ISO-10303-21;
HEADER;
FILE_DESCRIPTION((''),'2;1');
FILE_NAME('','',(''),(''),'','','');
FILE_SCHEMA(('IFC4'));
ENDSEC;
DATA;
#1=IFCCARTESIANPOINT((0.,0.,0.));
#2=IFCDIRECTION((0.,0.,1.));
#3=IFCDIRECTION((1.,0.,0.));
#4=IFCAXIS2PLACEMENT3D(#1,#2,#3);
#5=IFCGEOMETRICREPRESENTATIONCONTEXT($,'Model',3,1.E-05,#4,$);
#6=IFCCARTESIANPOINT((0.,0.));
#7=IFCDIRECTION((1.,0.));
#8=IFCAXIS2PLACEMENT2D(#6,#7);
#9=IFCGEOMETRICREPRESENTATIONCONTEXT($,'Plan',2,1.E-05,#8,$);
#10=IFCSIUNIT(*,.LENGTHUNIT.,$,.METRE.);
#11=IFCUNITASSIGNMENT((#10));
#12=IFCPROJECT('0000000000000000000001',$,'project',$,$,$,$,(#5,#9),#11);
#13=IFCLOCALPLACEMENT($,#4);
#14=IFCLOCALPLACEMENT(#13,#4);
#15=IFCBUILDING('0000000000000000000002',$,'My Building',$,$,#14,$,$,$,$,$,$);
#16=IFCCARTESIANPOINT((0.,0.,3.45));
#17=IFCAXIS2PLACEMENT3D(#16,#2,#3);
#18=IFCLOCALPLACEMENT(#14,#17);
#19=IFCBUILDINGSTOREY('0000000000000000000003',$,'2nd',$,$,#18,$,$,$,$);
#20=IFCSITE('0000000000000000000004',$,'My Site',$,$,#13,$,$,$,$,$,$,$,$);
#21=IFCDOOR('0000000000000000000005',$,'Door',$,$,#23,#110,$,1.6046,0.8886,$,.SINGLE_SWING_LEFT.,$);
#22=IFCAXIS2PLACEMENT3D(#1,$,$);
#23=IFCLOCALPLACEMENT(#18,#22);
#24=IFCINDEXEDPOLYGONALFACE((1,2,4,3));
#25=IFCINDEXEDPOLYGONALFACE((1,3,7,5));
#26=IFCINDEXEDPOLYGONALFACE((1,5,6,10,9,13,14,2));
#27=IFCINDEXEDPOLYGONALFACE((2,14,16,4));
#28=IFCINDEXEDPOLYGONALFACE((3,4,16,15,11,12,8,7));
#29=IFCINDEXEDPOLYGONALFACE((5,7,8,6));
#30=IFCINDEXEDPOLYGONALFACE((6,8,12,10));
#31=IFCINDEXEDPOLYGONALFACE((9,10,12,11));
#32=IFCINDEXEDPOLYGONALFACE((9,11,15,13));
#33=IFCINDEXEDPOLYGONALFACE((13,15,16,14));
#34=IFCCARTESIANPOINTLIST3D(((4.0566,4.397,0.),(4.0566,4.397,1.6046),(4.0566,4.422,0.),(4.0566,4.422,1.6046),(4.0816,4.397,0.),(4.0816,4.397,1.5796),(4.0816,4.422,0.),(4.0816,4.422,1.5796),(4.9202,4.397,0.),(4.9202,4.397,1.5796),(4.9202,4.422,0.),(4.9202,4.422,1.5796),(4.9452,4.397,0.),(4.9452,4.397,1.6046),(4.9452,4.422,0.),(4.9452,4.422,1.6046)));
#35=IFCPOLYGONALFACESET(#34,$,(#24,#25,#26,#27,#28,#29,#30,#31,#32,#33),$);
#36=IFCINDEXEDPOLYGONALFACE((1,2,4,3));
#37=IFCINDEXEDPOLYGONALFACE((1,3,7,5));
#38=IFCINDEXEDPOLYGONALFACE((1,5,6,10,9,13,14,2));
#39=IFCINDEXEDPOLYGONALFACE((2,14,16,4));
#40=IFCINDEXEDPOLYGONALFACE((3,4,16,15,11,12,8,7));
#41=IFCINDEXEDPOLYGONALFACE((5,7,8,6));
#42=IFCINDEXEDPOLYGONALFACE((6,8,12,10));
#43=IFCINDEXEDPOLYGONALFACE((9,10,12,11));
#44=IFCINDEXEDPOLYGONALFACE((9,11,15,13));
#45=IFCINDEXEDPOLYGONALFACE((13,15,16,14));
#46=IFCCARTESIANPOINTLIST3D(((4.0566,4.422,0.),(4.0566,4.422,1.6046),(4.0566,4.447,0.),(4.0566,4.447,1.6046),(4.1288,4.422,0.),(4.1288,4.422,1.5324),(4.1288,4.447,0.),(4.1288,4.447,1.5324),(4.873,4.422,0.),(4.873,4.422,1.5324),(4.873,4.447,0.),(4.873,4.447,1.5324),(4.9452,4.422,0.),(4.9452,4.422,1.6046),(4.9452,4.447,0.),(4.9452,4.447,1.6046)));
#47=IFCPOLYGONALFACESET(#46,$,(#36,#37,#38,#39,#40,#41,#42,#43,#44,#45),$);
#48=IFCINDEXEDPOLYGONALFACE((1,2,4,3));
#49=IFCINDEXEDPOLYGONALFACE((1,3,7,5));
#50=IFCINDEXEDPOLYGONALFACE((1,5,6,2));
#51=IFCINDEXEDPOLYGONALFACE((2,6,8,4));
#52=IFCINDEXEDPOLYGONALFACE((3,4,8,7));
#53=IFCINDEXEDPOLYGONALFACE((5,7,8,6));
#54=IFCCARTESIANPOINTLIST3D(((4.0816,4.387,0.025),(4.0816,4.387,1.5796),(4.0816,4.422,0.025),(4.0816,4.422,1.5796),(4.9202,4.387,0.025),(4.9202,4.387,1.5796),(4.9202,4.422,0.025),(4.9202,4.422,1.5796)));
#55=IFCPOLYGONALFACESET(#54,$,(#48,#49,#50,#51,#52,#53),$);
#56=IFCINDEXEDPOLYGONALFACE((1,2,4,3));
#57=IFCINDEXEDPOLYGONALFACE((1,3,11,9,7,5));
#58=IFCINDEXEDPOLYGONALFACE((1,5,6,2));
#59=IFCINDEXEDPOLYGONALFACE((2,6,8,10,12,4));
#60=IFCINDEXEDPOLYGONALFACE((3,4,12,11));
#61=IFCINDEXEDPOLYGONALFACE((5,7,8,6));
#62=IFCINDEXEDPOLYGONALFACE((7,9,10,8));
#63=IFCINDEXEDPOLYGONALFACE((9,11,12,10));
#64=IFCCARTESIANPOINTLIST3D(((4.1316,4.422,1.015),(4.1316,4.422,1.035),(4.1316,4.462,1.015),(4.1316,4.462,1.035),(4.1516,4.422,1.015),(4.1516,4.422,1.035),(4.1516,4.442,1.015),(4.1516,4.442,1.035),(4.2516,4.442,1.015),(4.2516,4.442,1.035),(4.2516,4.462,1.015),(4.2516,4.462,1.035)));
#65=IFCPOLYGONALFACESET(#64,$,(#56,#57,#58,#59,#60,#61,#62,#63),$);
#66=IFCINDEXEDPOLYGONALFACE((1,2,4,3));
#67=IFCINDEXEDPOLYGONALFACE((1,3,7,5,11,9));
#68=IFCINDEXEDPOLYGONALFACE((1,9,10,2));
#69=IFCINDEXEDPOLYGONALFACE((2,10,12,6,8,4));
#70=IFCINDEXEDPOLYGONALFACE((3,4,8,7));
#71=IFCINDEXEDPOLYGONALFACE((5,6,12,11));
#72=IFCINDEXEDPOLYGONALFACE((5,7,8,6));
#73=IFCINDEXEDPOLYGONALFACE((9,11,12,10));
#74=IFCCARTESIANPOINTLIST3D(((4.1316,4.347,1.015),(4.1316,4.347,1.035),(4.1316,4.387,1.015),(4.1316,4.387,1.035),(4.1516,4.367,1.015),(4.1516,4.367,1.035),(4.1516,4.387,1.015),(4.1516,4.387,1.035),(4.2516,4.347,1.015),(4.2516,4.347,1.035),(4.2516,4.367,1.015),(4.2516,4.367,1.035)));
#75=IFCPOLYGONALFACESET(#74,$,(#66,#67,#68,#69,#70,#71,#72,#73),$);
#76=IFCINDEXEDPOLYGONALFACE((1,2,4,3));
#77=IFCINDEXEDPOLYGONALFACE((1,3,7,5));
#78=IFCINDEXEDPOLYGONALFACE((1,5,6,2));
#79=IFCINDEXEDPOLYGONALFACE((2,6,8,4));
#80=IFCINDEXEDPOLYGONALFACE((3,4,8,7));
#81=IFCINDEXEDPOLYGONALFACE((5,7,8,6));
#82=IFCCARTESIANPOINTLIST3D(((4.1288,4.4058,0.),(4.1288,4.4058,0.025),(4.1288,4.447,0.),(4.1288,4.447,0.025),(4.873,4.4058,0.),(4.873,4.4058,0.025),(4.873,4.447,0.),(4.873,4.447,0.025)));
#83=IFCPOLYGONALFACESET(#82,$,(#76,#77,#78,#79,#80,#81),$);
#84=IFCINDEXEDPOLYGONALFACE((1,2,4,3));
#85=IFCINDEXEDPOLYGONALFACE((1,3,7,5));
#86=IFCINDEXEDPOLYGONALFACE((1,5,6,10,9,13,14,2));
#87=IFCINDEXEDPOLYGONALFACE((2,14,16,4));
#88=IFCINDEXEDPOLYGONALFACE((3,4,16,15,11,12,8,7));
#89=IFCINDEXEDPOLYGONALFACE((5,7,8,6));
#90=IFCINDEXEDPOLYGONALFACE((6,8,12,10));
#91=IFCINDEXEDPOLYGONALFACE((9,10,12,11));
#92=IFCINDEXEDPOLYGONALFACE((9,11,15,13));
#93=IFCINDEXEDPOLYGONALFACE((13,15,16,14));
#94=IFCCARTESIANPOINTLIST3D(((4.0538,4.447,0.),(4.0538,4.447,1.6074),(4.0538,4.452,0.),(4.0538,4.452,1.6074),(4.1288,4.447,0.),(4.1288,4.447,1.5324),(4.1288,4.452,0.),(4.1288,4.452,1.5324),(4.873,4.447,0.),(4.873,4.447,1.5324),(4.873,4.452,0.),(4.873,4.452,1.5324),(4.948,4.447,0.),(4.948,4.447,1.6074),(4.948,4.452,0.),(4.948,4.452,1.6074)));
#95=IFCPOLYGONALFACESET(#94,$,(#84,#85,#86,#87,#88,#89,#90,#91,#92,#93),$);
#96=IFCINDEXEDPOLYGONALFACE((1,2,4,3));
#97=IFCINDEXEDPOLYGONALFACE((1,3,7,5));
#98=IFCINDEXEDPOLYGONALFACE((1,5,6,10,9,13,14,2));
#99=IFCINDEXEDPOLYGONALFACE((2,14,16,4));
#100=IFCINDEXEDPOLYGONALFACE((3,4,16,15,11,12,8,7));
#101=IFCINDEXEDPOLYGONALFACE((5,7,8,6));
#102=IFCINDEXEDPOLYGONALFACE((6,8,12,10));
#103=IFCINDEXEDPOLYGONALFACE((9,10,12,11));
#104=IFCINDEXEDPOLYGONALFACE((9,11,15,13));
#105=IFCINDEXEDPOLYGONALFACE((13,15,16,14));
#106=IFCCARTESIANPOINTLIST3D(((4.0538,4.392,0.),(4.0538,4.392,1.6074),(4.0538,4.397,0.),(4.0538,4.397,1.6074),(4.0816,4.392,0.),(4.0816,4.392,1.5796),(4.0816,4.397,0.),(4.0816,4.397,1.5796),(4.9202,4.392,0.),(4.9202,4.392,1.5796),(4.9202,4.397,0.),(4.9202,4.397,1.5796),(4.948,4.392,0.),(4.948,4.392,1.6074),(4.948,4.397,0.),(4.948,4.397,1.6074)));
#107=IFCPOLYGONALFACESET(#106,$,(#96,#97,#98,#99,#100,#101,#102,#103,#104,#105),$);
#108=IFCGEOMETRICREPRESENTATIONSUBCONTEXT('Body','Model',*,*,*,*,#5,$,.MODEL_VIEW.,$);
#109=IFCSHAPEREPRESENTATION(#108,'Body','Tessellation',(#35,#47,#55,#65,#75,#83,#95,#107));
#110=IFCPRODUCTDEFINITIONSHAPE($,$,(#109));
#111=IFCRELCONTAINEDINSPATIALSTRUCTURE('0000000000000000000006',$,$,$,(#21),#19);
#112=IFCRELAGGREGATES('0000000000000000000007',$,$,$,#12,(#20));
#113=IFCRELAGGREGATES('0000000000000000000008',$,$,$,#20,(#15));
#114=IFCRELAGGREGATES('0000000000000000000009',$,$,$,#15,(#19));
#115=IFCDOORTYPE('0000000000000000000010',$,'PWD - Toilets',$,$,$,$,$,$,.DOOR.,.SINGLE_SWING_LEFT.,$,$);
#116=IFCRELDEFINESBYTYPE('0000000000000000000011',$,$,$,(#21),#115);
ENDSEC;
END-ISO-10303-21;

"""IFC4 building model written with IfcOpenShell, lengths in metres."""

from ifc_helpers import new_model, entity, si_unit, frame, origin_with_axes, origin_2d_with_axis, place, context, subcontext, project, spatial, line, indexed_curve, outline, extrude, shape, source, transform, mapped, type_object, type_shapes, element, save


model = new_model("IFC4")

# Units and contexts
model_context = context("Model", 3, precision=1e-05, world=origin_with_axes())
plan_context = context("Plan", 2, precision=1e-05, world=origin_2d_with_axis())
body_context_1 = subcontext(model_context, "Body", "Model", "MODEL_VIEW")
body_context_2 = subcontext(plan_context, "Body", "Plan", "PLAN_VIEW")
ifc_project = project(units=[si_unit("LENGTHUNIT", "METRE")], contexts=[model_context, plan_context])

# Site, building, storey
site_placement = place(None, origin_with_axes())
site = spatial("IfcSite", under=ifc_project, at=site_placement, Name="My Site")
building_placement = place(site_placement, origin_with_axes())
building = spatial("IfcBuilding", under=site, at=building_placement, Name="My Building")
storey_placement = place(building_placement, frame((0.0, 0.0, 3.45), z_axis=(0.0, 0.0, 1.0), x_axis=(1.0, 0.0, 0.0)))
storey = spatial("IfcBuildingStorey", under=building, at=storey_placement, Name="2nd")

# Door
door_type_1 = type_object("IfcDoorType", Name="PWD - Toilets", OperationType="SINGLE_SWING_LEFT", PredefinedType="DOOR")
shared_shape_1 = source(origin_with_axes(), body_context_1, "Body", "SweptSolid", [
    extrude(outline(indexed_curve([(0.0, 0.0), (0.0, 1.6046), (0.8886, 1.6046), (0.8886, 0.0), (0.8636, 0.0), (0.8636, 1.5796), (0.025, 1.5796), (0.025, 0.0)], segments=[line(1, 2, 3, 4, 5, 6, 7, 8, 1)])), frame((0.0, 0.025, 0.0), z_axis=(0.0, -1.0, 0.0), x_axis=(1.0, 0.0, 0.0)), (0.0, 0.0, -1.0), 0.025),
    extrude(outline(indexed_curve([(0.0, 0.0), (0.0, 1.6046), (0.8886, 1.6046), (0.8886, 0.0), (0.8164, 0.0), (0.8164, 1.5324), (0.0722, 1.5324), (0.0722, 0.0)], segments=[line(1, 2, 3, 4, 5, 6, 7, 8, 1)])), frame((0.0, 0.0, 0.0), z_axis=(0.0, -1.0, 0.0), x_axis=(1.0, 0.0, 0.0)), (0.0, 0.0, -1.0), 0.025),
    extrude(outline(indexed_curve([(0.0, 0.0), (0.8386, 0.0), (0.8386, 0.035), (0.0, 0.035)], segments=[line(1, 2, 3, 4, 1)])), frame((0.025, 0.025, 0.025), z_axis=(0.0, 0.0, 1.0), x_axis=(1.0, 0.0, 0.0)), (0.0, 0.0, 1.0), 1.5546),
    extrude(outline(indexed_curve([(0.0, 0.0), (0.0, -0.04), (-0.12, -0.04), (-0.12, -0.02), (-0.02, -0.02), (-0.02, 0.0)], segments=[line(1, 2, 3, 4, 5, 6, 1)])), frame((0.8136, 0.025, 1.015), z_axis=(0.0, 0.0, 1.0), x_axis=(1.0, 0.0, 0.0)), (0.0, 0.0, 1.0), 0.02),
    extrude(outline(indexed_curve([(0.0, 0.0), (0.0, 0.04), (-0.12, 0.04), (-0.12, 0.02), (-0.02, 0.02), (-0.02, 0.0)], segments=[line(1, 2, 3, 4, 5, 6, 1)])), frame((0.8136, 0.06, 1.015), z_axis=(0.0, 0.0, 1.0), x_axis=(1.0, 0.0, 0.0)), (0.0, 0.0, 1.0), 0.02),
    extrude(outline(indexed_curve([(0.0, 0.0), (0.7442, 0.0), (0.7442, 0.0412), (0.0, 0.0412)], segments=[line(1, 2, 3, 4, 1)])), frame((0.0722, 0.0, 0.0), z_axis=(0.0, 0.0, 1.0), x_axis=(1.0, 0.0, 0.0)), (0.0, 0.0, 1.0), 0.025),
    extrude(outline(indexed_curve([(0.0, 0.0), (0.0, 1.6074), (0.8942, 1.6074), (0.8942, 0.0), (0.8192, 0.0), (0.8192, 1.5324), (0.075, 1.5324), (0.075, 0.0)], segments=[line(1, 2, 3, 4, 5, 6, 7, 8, 1)])), frame((-0.0028, -0.005, 0.0), z_axis=(0.0, -1.0, 0.0), x_axis=(1.0, 0.0, 0.0)), (0.0, 0.0, -1.0), 0.005),
    extrude(outline(indexed_curve([(0.0, 0.0), (0.0, 1.6074), (0.8942, 1.6074), (0.8942, 0.0), (0.8664, 0.0), (0.8664, 1.5796), (0.0278, 1.5796), (0.0278, 0.0)], segments=[line(1, 2, 3, 4, 5, 6, 7, 8, 1)])), frame((-0.0028, 0.05, 0.0), z_axis=(0.0, -1.0, 0.0), x_axis=(1.0, 0.0, 0.0)), (0.0, 0.0, -1.0), 0.005),
])
shared_shape_2 = source(origin_with_axes(), body_context_2, "Body", "Curve2D", [
    entity("IfcIndexedPolyCurve", entity("IfcCartesianPointList2D", [[0.0, 0.0], [0.0, 0.05], [0.025, 0.05], [0.025, 0.025], [0.0722, 0.025], [0.0722, 0.0]]), [entity("IfcLineIndex", [1, 2, 3, 4, 5, 6, 1])]),
    entity("IfcIndexedPolyCurve", entity("IfcCartesianPointList2D", [[0.8886, 0.0], [0.8886, 0.05], [0.8636, 0.05], [0.8636, 0.025], [0.8164, 0.025], [0.8164, 0.0]]), [entity("IfcLineIndex", [1, 2, 3, 4, 5, 6, 1])]),
    entity("IfcTrimmedCurve", entity("IfcEllipse", entity("IfcAxis2Placement2D", entity("IfcCartesianPoint", [0.06, 0.05]), entity("IfcDirection", [1.0, 0.0])), 0.8036, 0.8386), [entity("IfcCartesianPoint", [0.8636, 0.05])], [entity("IfcCartesianPoint", [0.06, 0.8886])], True, "CARTESIAN"),
    entity("IfcIndexedPolyCurve", entity("IfcCartesianPointList2D", [[0.025, 0.05], [0.06, 0.05], [0.06, 0.8886], [0.025, 0.8886]]), [entity("IfcLineIndex", [1, 2, 3, 4, 1])]),
])
type_shapes(door_type_1, [shared_shape_1, shared_shape_2])
door_1_placement = place(storey_placement, frame((4.9452, 4.447, 0.0), z_axis=(0.0, 0.0, 1.0), x_axis=(-1.0, 0.0, 0.0)))
element("IfcDoor", 1, at=door_1_placement, inside=storey, type_object=door_type_1, Name="Door", OperationType="SINGLE_SWING_LEFT", OverallHeight=1.6046, OverallWidth=0.8886, shapes=[
    shape(body_context_1, "Body", "MappedRepresentation", [mapped(shared_shape_1, transform((0.0, 0.0, 0.0), x_axis=(1.0, 0.0, 0.0), y_axis=(0.0, 1.0, 0.0), z_axis=(0.0, 0.0, 1.0), scale=1.0))]),
    shape(body_context_2, "Body", "MappedRepresentation", [mapped(shared_shape_2, transform((0.0, 0.0, 0.0), x_axis=(1.0, 0.0, 0.0), y_axis=(0.0, 1.0, 0.0), z_axis=(0.0, 0.0, 1.0), scale=1.0))]),
])

save(model, "model.ifc")
